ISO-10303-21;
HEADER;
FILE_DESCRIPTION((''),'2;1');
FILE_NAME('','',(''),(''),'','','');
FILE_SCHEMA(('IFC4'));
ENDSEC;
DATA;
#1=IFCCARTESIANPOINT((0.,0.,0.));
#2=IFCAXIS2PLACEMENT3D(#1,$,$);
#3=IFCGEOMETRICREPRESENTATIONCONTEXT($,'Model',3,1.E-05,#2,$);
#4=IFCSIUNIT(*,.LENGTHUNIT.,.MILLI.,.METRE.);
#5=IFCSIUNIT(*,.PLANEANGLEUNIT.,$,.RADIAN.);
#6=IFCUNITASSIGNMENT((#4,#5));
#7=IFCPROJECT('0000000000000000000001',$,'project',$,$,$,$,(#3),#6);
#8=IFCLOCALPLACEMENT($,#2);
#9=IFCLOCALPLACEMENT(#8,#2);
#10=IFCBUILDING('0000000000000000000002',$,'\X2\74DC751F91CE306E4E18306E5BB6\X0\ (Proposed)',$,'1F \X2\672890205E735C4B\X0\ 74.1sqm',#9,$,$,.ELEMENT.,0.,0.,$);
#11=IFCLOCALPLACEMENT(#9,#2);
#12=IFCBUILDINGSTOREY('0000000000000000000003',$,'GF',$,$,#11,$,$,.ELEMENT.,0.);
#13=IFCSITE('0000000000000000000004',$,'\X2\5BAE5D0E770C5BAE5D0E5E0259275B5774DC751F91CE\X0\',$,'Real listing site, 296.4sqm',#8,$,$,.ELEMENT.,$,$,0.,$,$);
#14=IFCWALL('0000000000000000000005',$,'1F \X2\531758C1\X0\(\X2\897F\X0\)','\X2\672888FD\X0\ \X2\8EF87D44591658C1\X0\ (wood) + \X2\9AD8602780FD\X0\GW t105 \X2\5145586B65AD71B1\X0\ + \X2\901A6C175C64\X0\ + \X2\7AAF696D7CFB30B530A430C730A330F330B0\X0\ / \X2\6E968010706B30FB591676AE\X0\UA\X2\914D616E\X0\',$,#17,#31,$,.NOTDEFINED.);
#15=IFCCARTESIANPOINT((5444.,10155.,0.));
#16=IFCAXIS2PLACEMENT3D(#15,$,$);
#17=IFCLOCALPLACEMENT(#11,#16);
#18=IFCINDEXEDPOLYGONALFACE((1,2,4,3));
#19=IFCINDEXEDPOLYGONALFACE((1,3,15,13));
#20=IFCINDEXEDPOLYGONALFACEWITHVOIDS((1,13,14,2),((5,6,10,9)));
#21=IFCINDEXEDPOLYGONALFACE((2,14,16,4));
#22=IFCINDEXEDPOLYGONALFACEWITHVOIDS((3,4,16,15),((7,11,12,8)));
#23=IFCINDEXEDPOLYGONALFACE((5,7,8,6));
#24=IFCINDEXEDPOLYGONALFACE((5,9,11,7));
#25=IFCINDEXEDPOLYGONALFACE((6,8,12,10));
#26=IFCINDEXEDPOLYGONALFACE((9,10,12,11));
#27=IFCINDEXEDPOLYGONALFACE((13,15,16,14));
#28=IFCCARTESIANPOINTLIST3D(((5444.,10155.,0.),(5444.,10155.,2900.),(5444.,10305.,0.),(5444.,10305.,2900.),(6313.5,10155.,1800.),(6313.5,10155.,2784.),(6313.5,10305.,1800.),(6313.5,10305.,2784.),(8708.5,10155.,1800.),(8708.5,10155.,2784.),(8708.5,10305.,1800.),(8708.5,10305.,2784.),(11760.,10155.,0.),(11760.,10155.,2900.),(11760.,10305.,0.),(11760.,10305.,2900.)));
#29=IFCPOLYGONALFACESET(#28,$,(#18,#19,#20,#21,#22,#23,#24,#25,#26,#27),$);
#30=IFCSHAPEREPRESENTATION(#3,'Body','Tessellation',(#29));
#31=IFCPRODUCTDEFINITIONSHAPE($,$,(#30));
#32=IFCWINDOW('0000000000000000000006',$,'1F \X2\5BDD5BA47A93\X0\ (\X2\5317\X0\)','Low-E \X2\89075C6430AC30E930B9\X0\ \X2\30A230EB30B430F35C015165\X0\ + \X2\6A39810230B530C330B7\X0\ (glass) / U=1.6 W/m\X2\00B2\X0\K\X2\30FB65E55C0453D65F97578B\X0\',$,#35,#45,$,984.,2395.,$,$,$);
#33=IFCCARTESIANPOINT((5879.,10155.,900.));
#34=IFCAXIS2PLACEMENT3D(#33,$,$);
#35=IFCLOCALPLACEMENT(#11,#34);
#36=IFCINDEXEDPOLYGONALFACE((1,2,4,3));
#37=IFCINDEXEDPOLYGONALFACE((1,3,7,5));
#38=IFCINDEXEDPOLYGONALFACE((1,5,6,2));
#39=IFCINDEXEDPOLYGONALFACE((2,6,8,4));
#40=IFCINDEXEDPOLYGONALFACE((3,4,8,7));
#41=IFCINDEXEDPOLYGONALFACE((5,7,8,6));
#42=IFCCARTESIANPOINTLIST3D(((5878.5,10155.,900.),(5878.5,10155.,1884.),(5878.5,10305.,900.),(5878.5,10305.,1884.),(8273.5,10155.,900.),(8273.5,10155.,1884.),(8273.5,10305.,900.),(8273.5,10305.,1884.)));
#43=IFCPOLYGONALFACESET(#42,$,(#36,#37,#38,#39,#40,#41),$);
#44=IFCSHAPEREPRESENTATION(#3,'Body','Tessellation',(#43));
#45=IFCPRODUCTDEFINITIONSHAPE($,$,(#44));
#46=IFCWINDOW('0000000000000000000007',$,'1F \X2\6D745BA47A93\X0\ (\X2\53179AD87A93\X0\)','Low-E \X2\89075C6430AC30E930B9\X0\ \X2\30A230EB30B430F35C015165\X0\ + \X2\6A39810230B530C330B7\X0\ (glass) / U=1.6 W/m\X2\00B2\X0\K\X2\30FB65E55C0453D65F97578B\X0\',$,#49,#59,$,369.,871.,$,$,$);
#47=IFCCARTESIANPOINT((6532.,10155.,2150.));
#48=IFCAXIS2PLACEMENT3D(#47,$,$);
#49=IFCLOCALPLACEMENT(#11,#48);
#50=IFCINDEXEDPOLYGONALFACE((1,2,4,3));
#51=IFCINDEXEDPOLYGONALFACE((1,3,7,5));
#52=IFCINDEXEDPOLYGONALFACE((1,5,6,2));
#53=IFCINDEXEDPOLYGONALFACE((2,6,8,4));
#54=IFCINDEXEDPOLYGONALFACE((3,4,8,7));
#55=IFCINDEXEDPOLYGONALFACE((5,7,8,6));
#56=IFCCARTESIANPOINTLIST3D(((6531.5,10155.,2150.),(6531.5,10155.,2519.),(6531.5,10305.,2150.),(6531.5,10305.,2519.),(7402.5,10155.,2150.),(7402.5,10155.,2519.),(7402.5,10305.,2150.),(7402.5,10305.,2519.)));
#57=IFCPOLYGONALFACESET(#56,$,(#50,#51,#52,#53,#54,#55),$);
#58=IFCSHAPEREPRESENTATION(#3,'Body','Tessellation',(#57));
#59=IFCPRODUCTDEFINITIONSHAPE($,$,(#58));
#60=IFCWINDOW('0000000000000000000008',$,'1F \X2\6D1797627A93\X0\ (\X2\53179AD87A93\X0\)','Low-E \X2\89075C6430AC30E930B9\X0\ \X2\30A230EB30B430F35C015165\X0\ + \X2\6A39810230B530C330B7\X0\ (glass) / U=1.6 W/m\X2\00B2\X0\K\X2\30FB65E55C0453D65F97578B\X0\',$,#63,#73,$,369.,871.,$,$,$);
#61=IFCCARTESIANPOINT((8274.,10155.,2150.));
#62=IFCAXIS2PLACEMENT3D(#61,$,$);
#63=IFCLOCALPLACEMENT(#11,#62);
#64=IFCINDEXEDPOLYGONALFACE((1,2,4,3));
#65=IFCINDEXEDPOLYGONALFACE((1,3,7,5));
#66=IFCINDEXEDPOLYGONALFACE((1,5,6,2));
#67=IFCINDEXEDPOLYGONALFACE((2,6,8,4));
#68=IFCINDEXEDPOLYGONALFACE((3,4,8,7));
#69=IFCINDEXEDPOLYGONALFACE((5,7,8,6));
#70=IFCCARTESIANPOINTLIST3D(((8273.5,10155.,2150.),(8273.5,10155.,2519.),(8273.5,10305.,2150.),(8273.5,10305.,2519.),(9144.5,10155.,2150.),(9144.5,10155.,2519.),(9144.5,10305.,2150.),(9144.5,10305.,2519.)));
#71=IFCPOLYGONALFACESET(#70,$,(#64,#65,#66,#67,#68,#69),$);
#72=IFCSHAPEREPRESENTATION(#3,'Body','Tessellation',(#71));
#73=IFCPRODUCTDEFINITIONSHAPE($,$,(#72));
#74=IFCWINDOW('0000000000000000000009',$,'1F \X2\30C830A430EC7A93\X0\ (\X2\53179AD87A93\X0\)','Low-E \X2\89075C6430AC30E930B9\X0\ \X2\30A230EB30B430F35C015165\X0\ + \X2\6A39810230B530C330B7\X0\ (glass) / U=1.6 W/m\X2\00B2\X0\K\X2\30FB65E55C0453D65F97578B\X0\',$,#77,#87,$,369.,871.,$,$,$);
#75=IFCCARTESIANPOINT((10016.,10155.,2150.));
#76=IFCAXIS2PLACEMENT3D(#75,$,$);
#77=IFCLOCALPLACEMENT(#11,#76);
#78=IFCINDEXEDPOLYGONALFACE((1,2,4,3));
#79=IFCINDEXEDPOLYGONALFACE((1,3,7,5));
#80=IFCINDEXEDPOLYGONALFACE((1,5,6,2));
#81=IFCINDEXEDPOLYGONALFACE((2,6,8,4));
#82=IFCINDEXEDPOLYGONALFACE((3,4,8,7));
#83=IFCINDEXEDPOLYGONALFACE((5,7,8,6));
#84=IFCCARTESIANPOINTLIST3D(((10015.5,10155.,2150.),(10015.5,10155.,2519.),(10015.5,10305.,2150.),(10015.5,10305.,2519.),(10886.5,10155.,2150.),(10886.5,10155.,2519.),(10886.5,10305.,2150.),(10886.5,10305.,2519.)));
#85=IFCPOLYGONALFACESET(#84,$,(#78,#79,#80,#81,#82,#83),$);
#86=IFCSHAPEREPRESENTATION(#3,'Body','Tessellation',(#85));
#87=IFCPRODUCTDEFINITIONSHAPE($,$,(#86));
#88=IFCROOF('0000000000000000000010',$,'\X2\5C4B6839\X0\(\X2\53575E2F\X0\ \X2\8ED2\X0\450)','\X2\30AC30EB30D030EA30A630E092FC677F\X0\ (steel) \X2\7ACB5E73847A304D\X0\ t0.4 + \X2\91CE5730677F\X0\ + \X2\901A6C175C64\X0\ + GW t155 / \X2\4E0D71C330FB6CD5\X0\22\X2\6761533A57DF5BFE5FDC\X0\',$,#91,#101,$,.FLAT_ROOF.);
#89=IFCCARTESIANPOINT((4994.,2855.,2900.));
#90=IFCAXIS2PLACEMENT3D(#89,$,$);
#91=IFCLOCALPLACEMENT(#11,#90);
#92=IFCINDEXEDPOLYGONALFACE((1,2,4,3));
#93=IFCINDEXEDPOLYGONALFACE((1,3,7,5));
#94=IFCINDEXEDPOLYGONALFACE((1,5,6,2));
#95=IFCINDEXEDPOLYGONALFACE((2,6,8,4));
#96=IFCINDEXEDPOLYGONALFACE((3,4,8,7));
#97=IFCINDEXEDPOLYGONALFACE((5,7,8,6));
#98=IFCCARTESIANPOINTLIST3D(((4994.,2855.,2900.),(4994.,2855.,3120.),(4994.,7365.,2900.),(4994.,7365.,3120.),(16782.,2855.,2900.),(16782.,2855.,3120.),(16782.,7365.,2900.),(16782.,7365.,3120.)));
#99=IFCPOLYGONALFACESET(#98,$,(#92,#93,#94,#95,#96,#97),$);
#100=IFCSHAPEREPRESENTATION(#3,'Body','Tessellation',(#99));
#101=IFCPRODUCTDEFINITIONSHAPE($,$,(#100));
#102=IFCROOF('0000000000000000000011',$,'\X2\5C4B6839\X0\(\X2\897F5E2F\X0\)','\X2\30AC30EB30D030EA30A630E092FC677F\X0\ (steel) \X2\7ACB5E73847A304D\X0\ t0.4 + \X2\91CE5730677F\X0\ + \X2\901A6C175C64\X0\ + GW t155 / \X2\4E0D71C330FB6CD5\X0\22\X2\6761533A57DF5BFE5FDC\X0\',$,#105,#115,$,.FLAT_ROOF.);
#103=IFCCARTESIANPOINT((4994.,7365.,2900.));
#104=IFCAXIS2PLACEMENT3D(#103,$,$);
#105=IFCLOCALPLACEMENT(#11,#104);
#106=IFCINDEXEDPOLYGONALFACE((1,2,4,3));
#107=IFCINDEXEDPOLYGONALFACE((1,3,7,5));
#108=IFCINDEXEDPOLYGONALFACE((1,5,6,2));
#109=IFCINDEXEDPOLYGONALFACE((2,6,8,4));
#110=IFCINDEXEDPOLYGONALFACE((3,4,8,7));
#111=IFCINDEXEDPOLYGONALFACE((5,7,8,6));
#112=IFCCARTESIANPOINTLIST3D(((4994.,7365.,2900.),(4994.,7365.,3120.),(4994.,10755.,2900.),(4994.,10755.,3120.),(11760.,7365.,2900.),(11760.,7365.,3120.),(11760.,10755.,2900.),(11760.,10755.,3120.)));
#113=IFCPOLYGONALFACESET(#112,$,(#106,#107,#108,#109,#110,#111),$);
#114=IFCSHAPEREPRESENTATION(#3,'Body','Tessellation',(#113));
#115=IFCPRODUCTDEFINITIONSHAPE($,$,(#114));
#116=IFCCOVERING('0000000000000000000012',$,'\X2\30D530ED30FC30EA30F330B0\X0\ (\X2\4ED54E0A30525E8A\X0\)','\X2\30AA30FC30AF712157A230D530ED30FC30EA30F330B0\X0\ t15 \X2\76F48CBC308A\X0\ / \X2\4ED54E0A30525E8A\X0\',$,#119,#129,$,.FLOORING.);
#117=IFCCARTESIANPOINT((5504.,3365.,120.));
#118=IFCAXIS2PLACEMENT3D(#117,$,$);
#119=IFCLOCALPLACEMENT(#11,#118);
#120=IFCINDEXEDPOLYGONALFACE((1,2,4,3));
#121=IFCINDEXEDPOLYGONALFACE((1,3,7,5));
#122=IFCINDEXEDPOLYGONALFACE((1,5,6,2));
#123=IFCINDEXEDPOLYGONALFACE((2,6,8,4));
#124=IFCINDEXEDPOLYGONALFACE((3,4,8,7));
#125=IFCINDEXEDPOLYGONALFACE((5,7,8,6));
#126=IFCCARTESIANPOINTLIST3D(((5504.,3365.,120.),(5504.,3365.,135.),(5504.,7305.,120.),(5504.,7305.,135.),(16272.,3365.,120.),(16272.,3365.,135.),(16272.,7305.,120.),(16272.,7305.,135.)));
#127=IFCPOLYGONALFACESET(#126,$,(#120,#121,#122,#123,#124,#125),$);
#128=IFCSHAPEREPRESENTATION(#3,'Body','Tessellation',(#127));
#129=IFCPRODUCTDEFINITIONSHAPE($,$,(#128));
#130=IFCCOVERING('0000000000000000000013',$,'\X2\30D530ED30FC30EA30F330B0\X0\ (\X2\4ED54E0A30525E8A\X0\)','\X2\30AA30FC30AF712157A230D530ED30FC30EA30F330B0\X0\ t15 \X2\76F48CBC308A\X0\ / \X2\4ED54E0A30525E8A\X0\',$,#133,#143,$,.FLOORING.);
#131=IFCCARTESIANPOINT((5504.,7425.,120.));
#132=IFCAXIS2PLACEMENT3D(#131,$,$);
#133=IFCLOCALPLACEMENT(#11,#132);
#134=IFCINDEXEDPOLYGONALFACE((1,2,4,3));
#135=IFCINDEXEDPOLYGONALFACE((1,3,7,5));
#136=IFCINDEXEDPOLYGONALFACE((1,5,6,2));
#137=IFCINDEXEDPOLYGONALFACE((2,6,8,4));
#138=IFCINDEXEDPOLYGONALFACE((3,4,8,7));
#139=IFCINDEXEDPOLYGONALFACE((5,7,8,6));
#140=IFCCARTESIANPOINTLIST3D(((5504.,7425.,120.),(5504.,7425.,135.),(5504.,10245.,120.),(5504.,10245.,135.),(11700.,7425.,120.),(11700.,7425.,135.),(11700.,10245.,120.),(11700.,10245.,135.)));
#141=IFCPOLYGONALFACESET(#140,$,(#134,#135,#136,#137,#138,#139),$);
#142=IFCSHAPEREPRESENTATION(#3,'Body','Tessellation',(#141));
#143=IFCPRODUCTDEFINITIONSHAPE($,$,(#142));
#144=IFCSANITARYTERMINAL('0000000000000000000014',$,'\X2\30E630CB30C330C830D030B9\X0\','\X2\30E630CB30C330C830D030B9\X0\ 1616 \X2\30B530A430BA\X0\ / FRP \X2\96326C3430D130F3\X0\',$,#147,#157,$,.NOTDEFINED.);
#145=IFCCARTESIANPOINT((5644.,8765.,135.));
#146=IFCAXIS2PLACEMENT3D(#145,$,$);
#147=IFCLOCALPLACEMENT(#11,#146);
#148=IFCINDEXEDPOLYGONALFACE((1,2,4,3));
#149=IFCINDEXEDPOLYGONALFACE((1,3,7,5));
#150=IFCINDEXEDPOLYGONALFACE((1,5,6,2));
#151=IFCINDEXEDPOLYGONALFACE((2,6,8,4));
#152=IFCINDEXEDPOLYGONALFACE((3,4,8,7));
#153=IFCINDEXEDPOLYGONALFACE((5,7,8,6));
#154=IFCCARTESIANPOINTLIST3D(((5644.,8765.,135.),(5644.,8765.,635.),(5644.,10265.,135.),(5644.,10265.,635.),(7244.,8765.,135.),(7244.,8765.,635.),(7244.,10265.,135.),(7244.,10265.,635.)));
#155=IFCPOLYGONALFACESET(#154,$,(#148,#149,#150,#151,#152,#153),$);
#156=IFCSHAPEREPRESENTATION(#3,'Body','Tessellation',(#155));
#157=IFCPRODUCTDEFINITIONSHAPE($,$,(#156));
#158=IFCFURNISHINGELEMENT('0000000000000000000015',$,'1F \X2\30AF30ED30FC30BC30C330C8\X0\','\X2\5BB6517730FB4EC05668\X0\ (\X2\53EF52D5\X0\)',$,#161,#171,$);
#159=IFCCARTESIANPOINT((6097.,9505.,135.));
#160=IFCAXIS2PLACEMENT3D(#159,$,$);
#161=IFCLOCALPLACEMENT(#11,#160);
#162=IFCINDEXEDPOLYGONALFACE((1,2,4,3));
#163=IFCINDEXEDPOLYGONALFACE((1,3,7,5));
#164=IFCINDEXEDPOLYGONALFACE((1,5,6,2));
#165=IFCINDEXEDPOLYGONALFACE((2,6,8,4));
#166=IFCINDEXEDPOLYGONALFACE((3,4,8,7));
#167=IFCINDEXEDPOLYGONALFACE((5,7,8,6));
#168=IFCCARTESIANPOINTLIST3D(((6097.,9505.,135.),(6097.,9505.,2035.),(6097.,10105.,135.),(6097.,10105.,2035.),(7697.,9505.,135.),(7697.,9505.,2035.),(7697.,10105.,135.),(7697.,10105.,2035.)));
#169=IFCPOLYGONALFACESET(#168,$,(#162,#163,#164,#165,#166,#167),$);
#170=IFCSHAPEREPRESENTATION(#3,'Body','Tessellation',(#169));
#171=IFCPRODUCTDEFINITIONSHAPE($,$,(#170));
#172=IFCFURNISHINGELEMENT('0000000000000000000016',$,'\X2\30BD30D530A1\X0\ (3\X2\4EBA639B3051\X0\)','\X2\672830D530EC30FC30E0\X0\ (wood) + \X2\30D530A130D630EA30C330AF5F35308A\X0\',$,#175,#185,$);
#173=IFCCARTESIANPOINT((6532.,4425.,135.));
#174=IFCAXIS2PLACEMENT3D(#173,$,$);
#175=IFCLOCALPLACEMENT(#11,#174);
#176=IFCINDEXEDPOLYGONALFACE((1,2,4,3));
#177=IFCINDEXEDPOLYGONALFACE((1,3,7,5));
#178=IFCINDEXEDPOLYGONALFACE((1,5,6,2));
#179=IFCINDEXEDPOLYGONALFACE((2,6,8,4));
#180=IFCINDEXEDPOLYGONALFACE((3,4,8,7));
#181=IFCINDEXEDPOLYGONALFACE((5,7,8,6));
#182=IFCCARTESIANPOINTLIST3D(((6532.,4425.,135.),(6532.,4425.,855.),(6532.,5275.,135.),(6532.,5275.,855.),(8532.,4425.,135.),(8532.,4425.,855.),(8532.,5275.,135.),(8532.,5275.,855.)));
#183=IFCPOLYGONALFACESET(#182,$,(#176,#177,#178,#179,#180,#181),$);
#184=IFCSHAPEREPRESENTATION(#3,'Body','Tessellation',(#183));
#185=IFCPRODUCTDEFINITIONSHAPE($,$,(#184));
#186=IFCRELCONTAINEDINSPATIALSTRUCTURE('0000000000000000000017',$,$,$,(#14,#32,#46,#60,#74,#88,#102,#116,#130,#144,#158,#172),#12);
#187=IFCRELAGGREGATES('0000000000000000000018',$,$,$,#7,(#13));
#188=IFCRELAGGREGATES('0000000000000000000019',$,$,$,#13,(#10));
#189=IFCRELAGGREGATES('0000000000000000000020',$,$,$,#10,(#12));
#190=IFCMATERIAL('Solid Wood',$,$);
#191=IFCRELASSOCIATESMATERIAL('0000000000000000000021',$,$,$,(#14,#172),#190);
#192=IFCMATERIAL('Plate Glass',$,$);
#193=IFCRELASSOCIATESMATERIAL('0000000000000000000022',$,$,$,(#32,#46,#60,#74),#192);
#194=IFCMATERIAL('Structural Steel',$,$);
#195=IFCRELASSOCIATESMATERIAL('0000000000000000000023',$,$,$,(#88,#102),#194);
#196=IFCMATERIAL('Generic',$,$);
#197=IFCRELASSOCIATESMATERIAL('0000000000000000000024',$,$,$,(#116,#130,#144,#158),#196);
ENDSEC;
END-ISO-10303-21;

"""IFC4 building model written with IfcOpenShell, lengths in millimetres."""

from ifc_helpers import new_model, si_unit, frame, frame_2d, origin, place, context, project, spatial, rectangle, extrude, material, element, fill, save


model = new_model("IFC4")

# Units and contexts
model_context = context("Model", 3, precision=1e-05, world=origin())
ifc_project = project(units=[si_unit("LENGTHUNIT", "METRE", prefix="MILLI"), si_unit("PLANEANGLEUNIT", "RADIAN")], contexts=[model_context])

# Site, building, storey
site_placement = place(None, origin())
site = spatial("IfcSite", under=ifc_project, at=site_placement, Name="宮崎県宮崎市大字瓜生野", ObjectType="Real listing site, 296.4sqm", CompositionType="ELEMENT", RefElevation=0.0)
building_placement = place(site_placement, origin())
building = spatial("IfcBuilding", under=site, at=building_placement, Name="瓜生野の丘の家 (Proposed)", ObjectType="1F 木造平屋 74.1sqm", CompositionType="ELEMENT", ElevationOfRefHeight=0.0, ElevationOfTerrain=0.0)
storey_placement = place(building_placement, origin())
storey = spatial("IfcBuildingStorey", under=building, at=storey_placement, Name="GF", CompositionType="ELEMENT", Elevation=0.0)

# Shared definitions
ifc_material_1 = material(Name="Solid Wood")

# Shared definitions
ifc_material_2 = material(Name="Plate Glass")

# Wall, openings, windows
wall_1_placement = place(storey_placement, frame((5444.0, 10155.0, 0.0)))
wall_1 = element("IfcWall", 1, at=wall_1_placement, inside=storey, material=ifc_material_1, Name="1F 北壁(西)", Description="木製 軸組外壁 (wood) + 高性能GW t105 充填断熱 + 通気層 + 窯業系サイディング / 準耐火・外皮UA配慮", PredefinedType="NOTDEFINED", context=model_context, shape_type="SweptSolid", body=[
    extrude(rectangle(XDim=6316.0, YDim=150.0, at=frame_2d((3158.0, 75.0))), frame((5444.0, 10155.0, 0.0)), (0.0, 0.0, 1.0), 2900.0),
])
opening_1_placement = place(storey_placement, frame((5879.0, 10155.0, 900.0)))
opening_1 = element("IfcOpeningElement", 2, at=opening_1_placement, cuts=wall_1, PredefinedType="NOTDEFINED", context=model_context, shape_type="SweptSolid", body=[
    extrude(rectangle(XDim=2395.0, YDim=150.0, at=frame_2d((1197.0, 75.0))), frame((5879.0, 10155.0, 900.0)), (0.0, 0.0, 1.0), 984.0),
])
opening_2_placement = place(storey_placement, frame((6532.0, 10155.0, 2150.0)))
opening_2 = element("IfcOpeningElement", 3, at=opening_2_placement, cuts=wall_1, PredefinedType="NOTDEFINED", context=model_context, shape_type="SweptSolid", body=[
    extrude(rectangle(XDim=871.0, YDim=150.0, at=frame_2d((435.0, 75.0))), frame((6532.0, 10155.0, 2150.0)), (0.0, 0.0, 1.0), 369.0),
])
opening_3_placement = place(storey_placement, frame((8274.0, 10155.0, 2150.0)))
opening_3 = element("IfcOpeningElement", 4, at=opening_3_placement, cuts=wall_1, PredefinedType="NOTDEFINED", context=model_context, shape_type="SweptSolid", body=[
    extrude(rectangle(XDim=871.0, YDim=150.0, at=frame_2d((435.0, 75.0))), frame((8274.0, 10155.0, 2150.0)), (0.0, 0.0, 1.0), 369.0),
])
opening_4_placement = place(storey_placement, frame((10016.0, 10155.0, 2150.0)))
opening_4 = element("IfcOpeningElement", 5, at=opening_4_placement, cuts=wall_1, PredefinedType="NOTDEFINED", context=model_context, shape_type="SweptSolid", body=[
    extrude(rectangle(XDim=871.0, YDim=150.0, at=frame_2d((435.0, 75.0))), frame((10016.0, 10155.0, 2150.0)), (0.0, 0.0, 1.0), 369.0),
])
window_1_placement = place(storey_placement, frame((5879.0, 10155.0, 900.0)))
window_1 = element("IfcWindow", 6, at=window_1_placement, inside=storey, material=ifc_material_2, Name="1F 寝室窓 (北)", Description="Low-E 複層ガラス アルゴン封入 + 樹脂サッシ (glass) / U=1.6 W/m²K・日射取得型", OverallHeight=984.0, OverallWidth=2395.0, context=model_context, shape_type="SweptSolid", body=[
    extrude(rectangle(XDim=2395.0, YDim=150.0, at=frame_2d((1197.0, 75.0))), frame((5879.0, 10155.0, 900.0)), (0.0, 0.0, 1.0), 984.0),
])
fill(opening_1, window_1)
window_2_placement = place(storey_placement, frame((6532.0, 10155.0, 2150.0)))
window_2 = element("IfcWindow", 7, at=window_2_placement, inside=storey, material=ifc_material_2, Name="1F 浴室窓 (北高窓)", Description="Low-E 複層ガラス アルゴン封入 + 樹脂サッシ (glass) / U=1.6 W/m²K・日射取得型", OverallHeight=369.0, OverallWidth=871.0, context=model_context, shape_type="SweptSolid", body=[
    extrude(rectangle(XDim=871.0, YDim=150.0, at=frame_2d((435.0, 75.0))), frame((6532.0, 10155.0, 2150.0)), (0.0, 0.0, 1.0), 369.0),
])
fill(opening_2, window_2)
window_3_placement = place(storey_placement, frame((8274.0, 10155.0, 2150.0)))
window_3 = element("IfcWindow", 8, at=window_3_placement, inside=storey, material=ifc_material_2, Name="1F 洗面窓 (北高窓)", Description="Low-E 複層ガラス アルゴン封入 + 樹脂サッシ (glass) / U=1.6 W/m²K・日射取得型", OverallHeight=369.0, OverallWidth=871.0, context=model_context, shape_type="SweptSolid", body=[
    extrude(rectangle(XDim=871.0, YDim=150.0, at=frame_2d((435.0, 75.0))), frame((8274.0, 10155.0, 2150.0)), (0.0, 0.0, 1.0), 369.0),
])
fill(opening_3, window_3)
window_4_placement = place(storey_placement, frame((10016.0, 10155.0, 2150.0)))
window_4 = element("IfcWindow", 9, at=window_4_placement, inside=storey, material=ifc_material_2, Name="1F トイレ窓 (北高窓)", Description="Low-E 複層ガラス アルゴン封入 + 樹脂サッシ (glass) / U=1.6 W/m²K・日射取得型", OverallHeight=369.0, OverallWidth=871.0, context=model_context, shape_type="SweptSolid", body=[
    extrude(rectangle(XDim=871.0, YDim=150.0, at=frame_2d((435.0, 75.0))), frame((10016.0, 10155.0, 2150.0)), (0.0, 0.0, 1.0), 369.0),
])
fill(opening_4, window_4)

# Roofs
ifc_material_3 = material(Name="Structural Steel")
roof_1_placement = place(storey_placement, frame((4994.0, 2855.0, 2900.0)))
element("IfcRoof", 10, at=roof_1_placement, inside=storey, material=ifc_material_3, Name="屋根(南帯 軒450)", Description="ガルバリウム鋼板 (steel) 立平葺き t0.4 + 野地板 + 通気層 + GW t155 / 不燃・法22条区域対応", PredefinedType="FLAT_ROOF", context=model_context, shape_type="SweptSolid", body=[
    extrude(rectangle(XDim=11788.0, YDim=4510.0, at=frame_2d((5894.0, 2255.0))), frame((4994.0, 2855.0, 2900.0)), (0.0, 0.0, 1.0), 220.0),
])
roof_2_placement = place(storey_placement, frame((4994.0, 7365.0, 2900.0)))
element("IfcRoof", 11, at=roof_2_placement, inside=storey, material=ifc_material_3, Name="屋根(西帯)", Description="ガルバリウム鋼板 (steel) 立平葺き t0.4 + 野地板 + 通気層 + GW t155 / 不燃・法22条区域対応", PredefinedType="FLAT_ROOF", context=model_context, shape_type="SweptSolid", body=[
    extrude(rectangle(XDim=6766.0, YDim=3390.0, at=frame_2d((3383.0, 1695.0))), frame((4994.0, 7365.0, 2900.0)), (0.0, 0.0, 1.0), 220.0),
])

# Coverings
ifc_material_4 = material(Name="Generic")
covering_1_placement = place(storey_placement, frame((5504.0, 3365.0, 120.0)))
element("IfcCovering", 12, at=covering_1_placement, inside=storey, material=ifc_material_4, Name="フローリング (仕上げ床)", Description="オーク無垢フローリング t15 直貼り / 仕上げ床", PredefinedType="FLOORING", context=model_context, shape_type="SweptSolid", body=[
    extrude(rectangle(XDim=10768.0, YDim=3940.0, at=frame_2d((5384.0, 1970.0))), frame((5504.0, 3365.0, 120.0)), (0.0, 0.0, 1.0), 15.0),
])
covering_2_placement = place(storey_placement, frame((5504.0, 7425.0, 120.0)))
element("IfcCovering", 13, at=covering_2_placement, inside=storey, material=ifc_material_4, Name="フローリング (仕上げ床)", Description="オーク無垢フローリング t15 直貼り / 仕上げ床", PredefinedType="FLOORING", context=model_context, shape_type="SweptSolid", body=[
    extrude(rectangle(XDim=6196.0, YDim=2820.0, at=frame_2d((3098.0, 1410.0))), frame((5504.0, 7425.0, 120.0)), (0.0, 0.0, 1.0), 15.0),
])

# Sanitary terminal
sanitary_terminal_placement = place(storey_placement, frame((5644.0, 8765.0, 135.0)))
element("IfcSanitaryTerminal", 14, at=sanitary_terminal_placement, inside=storey, material=ifc_material_4, Name="ユニットバス", Description="ユニットバス 1616 サイズ / FRP 防水パン", PredefinedType="NOTDEFINED", context=model_context, shape_type="SweptSolid", body=[
    extrude(rectangle(XDim=1600.0, YDim=1500.0, at=frame_2d((800.0, 750.0))), frame((5644.0, 8765.0, 135.0)), (0.0, 0.0, 1.0), 500.0),
])

# Furnishing elements
furnishing_1_placement = place(storey_placement, frame((6097.0, 9505.0, 135.0)))
element("IfcFurnishingElement", 15, at=furnishing_1_placement, inside=storey, material=ifc_material_4, Name="1F クローゼット", Description="家具・什器 (可動)", context=model_context, shape_type="SweptSolid", body=[
    extrude(rectangle(XDim=1600.0, YDim=600.0, at=frame_2d((800.0, 300.0))), frame((6097.0, 9505.0, 135.0)), (0.0, 0.0, 1.0), 1900.0),
])
furnishing_2_placement = place(storey_placement, frame((6532.0, 4425.0, 135.0)))
element("IfcFurnishingElement", 16, at=furnishing_2_placement, inside=storey, material=ifc_material_1, Name="ソファ (3人掛け)", Description="木フレーム (wood) + ファブリック張り", context=model_context, shape_type="SweptSolid", body=[
    extrude(rectangle(XDim=2000.0, YDim=850.0, at=frame_2d((1000.0, 425.0))), frame((6532.0, 4425.0, 135.0)), (0.0, 0.0, 1.0), 720.0),
])

save(model, "model.ifc")
